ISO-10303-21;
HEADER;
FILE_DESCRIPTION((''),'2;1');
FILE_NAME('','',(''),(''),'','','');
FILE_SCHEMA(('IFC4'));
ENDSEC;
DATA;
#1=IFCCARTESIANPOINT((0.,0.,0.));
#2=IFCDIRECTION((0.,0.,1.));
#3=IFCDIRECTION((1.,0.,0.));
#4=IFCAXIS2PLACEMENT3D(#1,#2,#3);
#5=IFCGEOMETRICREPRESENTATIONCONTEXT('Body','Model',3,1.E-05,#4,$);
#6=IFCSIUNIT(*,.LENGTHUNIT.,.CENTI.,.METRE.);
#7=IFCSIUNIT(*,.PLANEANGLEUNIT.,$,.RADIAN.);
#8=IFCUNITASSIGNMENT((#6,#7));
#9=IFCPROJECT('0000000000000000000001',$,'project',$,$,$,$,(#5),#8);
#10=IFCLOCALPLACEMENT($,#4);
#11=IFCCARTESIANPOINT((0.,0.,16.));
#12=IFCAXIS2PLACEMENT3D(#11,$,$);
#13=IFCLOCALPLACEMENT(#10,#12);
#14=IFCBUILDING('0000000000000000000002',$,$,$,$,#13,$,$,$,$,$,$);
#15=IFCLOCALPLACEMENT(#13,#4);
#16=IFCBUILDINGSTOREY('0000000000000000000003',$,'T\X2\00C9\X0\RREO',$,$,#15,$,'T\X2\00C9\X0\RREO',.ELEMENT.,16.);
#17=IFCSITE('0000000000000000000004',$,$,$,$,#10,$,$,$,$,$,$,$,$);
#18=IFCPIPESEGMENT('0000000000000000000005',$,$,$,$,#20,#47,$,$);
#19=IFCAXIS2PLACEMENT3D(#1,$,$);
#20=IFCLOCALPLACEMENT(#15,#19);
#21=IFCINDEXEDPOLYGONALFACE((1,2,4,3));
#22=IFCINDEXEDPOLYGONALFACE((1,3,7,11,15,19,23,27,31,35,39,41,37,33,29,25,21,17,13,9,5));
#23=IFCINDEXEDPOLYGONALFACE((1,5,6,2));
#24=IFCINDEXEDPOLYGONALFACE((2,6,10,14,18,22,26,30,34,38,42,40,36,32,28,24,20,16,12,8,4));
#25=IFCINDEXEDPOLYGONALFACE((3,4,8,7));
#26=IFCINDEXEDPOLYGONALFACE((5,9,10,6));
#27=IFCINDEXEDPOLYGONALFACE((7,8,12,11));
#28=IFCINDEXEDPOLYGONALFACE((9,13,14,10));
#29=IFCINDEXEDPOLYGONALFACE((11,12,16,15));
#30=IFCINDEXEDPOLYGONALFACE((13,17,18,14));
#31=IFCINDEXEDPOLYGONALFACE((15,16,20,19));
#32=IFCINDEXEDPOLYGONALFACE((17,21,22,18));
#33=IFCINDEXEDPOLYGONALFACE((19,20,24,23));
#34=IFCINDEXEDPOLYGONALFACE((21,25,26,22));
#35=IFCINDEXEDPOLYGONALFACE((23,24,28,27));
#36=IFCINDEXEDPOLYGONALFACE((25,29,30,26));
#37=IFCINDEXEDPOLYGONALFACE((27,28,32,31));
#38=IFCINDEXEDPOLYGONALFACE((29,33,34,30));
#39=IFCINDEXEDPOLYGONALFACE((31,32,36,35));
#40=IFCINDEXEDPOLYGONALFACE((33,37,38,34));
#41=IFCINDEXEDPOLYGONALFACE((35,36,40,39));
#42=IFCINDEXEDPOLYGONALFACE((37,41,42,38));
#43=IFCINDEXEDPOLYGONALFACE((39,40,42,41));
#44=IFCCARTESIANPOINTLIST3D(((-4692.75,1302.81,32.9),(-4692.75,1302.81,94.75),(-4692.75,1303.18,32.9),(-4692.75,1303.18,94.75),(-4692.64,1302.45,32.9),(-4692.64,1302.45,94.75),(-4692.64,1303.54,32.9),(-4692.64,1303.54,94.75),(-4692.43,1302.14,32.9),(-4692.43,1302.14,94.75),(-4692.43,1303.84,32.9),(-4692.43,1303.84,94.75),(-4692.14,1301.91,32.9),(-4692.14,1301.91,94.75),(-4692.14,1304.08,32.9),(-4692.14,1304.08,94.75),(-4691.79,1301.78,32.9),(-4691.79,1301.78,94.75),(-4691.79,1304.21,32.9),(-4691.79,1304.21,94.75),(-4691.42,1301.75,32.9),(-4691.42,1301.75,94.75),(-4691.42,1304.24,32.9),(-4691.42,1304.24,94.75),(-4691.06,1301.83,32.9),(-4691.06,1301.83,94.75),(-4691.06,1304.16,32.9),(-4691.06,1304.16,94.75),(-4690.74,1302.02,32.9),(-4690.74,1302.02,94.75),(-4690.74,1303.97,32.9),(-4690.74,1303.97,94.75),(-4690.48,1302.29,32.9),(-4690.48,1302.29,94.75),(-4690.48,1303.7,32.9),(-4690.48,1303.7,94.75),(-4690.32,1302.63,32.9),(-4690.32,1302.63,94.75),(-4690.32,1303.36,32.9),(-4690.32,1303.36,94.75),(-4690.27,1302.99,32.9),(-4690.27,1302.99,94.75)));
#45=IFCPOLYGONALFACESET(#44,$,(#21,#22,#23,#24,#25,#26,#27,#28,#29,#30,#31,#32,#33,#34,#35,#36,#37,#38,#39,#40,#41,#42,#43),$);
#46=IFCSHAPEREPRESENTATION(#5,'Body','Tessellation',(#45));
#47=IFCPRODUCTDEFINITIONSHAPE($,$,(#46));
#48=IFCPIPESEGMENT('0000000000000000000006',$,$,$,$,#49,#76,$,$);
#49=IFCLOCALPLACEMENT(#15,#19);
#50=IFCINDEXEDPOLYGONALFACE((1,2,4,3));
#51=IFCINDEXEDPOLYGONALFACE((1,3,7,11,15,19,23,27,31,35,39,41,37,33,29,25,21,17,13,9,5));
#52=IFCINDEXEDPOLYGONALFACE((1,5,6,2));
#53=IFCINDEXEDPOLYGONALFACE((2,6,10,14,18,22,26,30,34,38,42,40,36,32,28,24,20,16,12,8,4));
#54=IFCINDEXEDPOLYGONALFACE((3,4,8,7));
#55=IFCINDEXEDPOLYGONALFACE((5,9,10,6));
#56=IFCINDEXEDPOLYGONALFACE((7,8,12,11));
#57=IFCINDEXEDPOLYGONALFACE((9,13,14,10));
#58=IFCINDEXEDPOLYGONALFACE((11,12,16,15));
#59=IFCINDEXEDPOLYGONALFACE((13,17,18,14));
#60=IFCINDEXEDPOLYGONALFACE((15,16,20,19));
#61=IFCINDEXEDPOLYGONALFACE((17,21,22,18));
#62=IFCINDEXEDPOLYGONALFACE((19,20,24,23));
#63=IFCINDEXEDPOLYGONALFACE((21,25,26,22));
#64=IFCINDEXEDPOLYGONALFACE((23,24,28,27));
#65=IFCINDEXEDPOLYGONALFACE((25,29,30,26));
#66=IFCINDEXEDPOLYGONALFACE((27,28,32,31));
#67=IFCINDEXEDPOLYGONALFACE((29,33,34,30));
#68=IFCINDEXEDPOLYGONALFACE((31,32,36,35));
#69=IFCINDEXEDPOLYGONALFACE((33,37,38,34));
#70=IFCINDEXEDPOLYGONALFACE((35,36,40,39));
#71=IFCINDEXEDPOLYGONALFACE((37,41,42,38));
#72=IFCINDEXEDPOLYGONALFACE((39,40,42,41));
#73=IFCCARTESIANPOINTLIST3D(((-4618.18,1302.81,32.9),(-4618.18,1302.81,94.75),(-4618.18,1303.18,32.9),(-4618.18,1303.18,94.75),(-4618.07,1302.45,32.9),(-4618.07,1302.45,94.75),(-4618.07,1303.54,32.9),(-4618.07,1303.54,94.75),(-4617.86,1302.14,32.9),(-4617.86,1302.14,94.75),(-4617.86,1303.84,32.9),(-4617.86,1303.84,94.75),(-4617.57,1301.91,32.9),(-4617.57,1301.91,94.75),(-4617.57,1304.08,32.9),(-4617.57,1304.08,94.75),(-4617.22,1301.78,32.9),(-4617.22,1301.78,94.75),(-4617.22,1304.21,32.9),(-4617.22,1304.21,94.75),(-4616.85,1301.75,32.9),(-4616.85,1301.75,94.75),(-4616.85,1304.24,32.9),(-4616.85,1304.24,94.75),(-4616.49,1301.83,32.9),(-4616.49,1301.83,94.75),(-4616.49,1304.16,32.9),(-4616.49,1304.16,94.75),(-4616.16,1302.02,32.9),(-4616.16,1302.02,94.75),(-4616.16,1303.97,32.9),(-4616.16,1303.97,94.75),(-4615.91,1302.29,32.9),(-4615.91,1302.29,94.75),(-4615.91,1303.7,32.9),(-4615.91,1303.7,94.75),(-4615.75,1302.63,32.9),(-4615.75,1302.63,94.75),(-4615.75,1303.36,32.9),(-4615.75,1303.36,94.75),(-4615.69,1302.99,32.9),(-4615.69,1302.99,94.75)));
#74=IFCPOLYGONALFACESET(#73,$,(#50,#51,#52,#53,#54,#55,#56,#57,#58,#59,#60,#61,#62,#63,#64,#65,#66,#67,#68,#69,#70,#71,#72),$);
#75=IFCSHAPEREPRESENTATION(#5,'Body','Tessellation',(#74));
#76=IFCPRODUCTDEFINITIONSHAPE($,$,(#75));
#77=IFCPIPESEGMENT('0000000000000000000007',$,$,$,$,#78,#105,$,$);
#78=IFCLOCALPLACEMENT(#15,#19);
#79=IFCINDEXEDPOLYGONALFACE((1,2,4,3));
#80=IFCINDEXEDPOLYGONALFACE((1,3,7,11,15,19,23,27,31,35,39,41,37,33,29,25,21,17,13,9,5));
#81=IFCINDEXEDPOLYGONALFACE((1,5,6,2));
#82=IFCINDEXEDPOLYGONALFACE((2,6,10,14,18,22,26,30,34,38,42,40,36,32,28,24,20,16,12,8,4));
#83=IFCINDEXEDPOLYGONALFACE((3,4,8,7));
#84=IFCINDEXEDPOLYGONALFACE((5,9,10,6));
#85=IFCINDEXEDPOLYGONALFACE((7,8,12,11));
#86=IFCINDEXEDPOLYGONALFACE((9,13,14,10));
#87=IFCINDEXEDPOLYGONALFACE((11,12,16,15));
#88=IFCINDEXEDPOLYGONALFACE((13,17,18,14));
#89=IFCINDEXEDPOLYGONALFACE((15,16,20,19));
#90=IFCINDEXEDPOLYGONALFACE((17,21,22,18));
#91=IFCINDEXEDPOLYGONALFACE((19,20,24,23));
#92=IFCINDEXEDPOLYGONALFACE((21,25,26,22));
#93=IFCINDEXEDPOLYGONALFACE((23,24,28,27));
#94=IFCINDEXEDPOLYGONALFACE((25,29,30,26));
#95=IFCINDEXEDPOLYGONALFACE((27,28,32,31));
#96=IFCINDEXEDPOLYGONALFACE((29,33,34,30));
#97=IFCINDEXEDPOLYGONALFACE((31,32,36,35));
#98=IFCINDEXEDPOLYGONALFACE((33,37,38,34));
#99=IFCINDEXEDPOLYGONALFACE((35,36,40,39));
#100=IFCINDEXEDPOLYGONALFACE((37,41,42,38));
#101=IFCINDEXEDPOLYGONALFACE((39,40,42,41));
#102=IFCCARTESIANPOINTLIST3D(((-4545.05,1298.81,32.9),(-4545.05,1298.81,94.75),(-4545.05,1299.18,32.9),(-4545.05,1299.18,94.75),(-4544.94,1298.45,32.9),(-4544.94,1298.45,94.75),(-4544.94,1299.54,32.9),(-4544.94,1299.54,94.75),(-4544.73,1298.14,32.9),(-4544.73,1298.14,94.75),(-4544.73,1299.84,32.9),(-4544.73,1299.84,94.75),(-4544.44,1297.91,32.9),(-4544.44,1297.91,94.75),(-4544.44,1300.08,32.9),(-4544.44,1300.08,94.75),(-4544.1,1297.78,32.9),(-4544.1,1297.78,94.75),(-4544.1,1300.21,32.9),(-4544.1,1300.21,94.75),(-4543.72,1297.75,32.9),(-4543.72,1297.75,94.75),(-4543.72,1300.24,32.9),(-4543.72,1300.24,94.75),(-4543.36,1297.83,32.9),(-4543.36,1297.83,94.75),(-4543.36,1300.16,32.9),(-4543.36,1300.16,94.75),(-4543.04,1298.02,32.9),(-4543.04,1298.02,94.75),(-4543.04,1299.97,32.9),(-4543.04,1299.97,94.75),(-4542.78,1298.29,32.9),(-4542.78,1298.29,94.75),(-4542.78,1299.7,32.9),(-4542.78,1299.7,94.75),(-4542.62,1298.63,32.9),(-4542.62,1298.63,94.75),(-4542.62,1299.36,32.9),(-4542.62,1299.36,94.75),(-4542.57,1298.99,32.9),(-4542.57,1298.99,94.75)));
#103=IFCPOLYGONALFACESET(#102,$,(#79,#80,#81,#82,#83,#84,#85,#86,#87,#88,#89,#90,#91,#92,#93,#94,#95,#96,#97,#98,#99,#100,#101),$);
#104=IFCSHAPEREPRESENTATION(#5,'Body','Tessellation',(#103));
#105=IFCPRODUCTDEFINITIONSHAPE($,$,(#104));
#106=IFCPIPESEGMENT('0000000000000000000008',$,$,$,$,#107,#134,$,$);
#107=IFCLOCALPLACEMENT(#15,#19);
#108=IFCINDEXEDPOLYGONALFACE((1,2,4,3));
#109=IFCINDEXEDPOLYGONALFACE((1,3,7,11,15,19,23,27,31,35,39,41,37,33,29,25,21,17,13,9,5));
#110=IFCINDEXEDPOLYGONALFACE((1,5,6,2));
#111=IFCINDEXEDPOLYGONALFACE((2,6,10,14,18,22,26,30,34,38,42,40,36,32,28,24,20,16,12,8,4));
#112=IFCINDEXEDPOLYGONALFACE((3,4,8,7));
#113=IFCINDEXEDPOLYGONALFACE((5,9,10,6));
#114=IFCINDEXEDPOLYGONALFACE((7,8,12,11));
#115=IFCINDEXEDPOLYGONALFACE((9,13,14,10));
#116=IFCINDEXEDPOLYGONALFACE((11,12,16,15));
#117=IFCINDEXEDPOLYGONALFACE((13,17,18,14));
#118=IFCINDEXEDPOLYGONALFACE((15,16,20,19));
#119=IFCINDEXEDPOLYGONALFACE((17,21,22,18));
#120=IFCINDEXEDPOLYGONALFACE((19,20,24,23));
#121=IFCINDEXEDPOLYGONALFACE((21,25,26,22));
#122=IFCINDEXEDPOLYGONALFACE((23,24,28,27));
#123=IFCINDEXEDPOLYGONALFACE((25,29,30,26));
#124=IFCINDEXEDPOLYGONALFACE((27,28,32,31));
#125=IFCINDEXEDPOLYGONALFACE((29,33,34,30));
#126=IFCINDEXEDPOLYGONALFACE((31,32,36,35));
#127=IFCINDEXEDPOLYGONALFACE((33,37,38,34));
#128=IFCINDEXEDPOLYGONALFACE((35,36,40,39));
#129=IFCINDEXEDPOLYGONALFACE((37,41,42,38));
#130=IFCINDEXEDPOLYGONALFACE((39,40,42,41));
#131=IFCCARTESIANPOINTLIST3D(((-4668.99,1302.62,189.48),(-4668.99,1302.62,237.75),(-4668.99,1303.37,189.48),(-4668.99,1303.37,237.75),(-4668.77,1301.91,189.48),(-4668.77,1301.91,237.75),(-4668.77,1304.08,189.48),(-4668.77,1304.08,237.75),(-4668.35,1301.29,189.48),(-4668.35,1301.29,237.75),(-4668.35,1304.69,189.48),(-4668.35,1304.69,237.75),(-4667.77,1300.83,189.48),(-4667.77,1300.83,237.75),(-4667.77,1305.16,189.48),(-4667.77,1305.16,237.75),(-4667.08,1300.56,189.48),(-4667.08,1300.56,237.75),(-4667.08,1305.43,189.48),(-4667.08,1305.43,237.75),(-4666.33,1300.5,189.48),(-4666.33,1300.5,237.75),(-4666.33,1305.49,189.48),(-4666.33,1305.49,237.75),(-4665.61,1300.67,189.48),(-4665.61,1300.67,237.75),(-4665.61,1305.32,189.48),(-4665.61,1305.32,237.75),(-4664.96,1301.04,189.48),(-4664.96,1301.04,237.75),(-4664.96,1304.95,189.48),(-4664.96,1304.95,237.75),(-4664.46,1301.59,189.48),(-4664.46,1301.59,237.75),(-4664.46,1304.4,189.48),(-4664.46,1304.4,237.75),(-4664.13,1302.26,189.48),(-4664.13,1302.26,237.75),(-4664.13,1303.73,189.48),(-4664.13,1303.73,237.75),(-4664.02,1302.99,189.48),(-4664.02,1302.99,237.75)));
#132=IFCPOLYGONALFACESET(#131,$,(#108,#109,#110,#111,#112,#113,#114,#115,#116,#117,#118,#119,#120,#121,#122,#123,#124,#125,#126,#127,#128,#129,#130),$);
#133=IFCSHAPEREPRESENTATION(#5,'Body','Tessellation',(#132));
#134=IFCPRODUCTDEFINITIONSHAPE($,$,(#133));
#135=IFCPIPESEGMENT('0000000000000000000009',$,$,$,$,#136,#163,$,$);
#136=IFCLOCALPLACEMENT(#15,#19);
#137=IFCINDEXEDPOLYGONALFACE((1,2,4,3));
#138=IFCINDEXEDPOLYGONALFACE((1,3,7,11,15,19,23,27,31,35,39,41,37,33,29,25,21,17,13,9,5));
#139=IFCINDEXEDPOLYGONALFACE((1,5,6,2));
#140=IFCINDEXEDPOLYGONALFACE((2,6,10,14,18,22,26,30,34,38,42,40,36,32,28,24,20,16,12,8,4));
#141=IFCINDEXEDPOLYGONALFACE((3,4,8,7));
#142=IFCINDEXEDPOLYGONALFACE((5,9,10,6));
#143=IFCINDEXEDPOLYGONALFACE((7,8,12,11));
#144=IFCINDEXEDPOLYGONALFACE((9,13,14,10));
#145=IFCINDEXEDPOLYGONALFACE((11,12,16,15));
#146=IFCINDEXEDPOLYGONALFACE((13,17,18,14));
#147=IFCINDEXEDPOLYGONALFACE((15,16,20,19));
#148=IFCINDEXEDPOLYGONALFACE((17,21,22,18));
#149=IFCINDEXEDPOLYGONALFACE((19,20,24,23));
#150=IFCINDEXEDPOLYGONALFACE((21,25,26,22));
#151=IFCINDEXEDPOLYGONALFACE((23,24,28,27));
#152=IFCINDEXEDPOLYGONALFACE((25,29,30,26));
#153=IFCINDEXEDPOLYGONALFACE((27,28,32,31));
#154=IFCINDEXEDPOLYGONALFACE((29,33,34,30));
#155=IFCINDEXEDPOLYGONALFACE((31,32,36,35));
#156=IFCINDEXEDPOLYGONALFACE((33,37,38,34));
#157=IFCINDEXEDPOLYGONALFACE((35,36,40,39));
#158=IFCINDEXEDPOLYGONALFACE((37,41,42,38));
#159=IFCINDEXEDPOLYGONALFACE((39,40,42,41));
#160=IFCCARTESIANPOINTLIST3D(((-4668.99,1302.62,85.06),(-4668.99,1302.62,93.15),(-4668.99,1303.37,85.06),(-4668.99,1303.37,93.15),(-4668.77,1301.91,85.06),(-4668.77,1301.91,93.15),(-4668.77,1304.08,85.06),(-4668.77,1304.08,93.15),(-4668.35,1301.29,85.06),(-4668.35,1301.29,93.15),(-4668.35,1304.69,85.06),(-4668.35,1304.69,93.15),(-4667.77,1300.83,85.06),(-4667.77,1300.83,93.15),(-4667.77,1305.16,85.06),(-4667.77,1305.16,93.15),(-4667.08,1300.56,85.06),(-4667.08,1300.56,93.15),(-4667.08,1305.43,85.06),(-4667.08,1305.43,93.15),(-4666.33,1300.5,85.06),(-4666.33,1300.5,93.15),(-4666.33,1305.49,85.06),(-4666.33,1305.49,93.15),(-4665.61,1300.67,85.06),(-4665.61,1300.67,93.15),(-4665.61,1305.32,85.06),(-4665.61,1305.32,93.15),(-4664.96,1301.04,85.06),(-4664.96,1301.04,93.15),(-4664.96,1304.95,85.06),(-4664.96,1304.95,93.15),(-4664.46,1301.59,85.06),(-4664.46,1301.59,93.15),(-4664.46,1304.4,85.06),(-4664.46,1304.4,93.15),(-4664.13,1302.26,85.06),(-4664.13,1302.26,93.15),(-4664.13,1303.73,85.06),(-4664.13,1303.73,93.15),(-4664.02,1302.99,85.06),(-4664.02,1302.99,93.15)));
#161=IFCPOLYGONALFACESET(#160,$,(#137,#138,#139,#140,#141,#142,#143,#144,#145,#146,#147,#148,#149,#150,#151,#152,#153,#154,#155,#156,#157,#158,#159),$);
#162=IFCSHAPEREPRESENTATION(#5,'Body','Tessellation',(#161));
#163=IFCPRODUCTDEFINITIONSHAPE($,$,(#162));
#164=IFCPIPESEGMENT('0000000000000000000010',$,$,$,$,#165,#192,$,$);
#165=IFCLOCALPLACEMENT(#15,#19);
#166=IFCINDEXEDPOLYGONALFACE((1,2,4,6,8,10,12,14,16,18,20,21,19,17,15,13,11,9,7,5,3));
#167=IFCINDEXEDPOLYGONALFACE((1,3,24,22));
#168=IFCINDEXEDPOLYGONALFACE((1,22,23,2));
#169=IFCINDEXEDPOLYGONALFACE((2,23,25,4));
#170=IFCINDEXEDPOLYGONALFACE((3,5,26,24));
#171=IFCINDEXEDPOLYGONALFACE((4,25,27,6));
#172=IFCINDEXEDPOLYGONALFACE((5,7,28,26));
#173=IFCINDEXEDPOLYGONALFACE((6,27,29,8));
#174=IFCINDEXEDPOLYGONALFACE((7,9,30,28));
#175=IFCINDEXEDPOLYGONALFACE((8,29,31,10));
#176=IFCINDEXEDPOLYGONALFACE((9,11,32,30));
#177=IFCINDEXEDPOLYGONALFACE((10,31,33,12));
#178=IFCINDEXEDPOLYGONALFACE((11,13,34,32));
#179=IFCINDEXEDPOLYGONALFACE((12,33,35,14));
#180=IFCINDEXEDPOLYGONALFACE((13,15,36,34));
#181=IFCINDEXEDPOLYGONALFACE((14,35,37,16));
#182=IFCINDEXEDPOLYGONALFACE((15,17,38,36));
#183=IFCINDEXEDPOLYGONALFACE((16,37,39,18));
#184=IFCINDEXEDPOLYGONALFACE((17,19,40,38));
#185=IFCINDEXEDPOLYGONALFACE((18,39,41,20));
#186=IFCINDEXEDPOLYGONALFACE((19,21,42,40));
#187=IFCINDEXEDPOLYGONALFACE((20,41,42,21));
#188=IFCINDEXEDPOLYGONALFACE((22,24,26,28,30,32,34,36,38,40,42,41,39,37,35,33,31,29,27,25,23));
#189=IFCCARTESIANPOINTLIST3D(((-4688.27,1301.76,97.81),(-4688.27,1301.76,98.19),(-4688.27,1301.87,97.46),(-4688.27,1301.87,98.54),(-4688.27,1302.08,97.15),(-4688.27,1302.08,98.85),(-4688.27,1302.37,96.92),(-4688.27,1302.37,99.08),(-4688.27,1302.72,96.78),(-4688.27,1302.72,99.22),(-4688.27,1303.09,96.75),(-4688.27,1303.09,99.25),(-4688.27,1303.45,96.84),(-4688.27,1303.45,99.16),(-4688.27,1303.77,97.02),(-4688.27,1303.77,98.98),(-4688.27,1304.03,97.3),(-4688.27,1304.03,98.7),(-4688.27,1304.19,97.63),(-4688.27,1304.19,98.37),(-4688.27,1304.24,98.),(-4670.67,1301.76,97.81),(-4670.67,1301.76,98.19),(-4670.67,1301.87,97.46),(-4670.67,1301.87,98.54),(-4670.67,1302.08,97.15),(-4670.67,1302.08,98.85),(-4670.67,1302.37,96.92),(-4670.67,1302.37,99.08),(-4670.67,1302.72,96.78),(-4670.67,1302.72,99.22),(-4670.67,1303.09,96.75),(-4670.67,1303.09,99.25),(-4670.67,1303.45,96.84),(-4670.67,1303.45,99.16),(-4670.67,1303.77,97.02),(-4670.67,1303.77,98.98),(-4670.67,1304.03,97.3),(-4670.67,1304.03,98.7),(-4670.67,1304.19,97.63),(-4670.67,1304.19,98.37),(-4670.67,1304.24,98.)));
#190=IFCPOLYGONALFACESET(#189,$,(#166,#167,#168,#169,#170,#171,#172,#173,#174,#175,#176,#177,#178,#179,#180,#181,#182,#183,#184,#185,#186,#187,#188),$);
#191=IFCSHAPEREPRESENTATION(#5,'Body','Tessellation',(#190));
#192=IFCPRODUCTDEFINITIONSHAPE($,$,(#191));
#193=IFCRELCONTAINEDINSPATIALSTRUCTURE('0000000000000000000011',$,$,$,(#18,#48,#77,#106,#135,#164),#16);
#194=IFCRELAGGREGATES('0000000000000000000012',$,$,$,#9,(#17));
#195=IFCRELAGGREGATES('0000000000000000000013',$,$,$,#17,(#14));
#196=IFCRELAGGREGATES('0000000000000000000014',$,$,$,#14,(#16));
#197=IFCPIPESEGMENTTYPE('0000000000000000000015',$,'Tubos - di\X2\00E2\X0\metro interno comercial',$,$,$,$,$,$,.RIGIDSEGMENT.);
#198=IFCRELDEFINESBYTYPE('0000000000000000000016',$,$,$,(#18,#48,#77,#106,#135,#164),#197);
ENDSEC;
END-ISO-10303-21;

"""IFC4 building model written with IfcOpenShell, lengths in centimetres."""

from ifc_helpers import new_model, si_unit, frame, origin_with_axes, origin_2d_with_axis, place, context, project, spatial, circle, extrude, type_object, element, save


model = new_model("IFC4")

# Units and contexts
model_context = context("Model", 3, precision=1e-05, world=origin_with_axes(), identifier="Body")
ifc_project = project(units=[si_unit("LENGTHUNIT", "METRE", prefix="CENTI"), si_unit("PLANEANGLEUNIT", "RADIAN")], contexts=[model_context])

# Site, building, storey
site_placement = place(None, origin_with_axes())
site = spatial("IfcSite", under=ifc_project, at=site_placement)
building_placement = place(site_placement, frame((0.0, 0.0, 16.0)))
building = spatial("IfcBuilding", under=site, at=building_placement)
storey_placement = place(building_placement, origin_with_axes())
storey = spatial("IfcBuildingStorey", under=building, at=storey_placement, Name="TÉRREO", LongName="TÉRREO", CompositionType="ELEMENT", Elevation=16.0)

# Pipe segments
pipe_segment_type = type_object("IfcPipeSegmentType", Name="Tubos - diâmetro interno comercial", PredefinedType="RIGIDSEGMENT")
for number, where, z_axis, x_axis in (
    (1, (-4691.52, 1302.99, 94.75), (0.0, 0.0, 1.0), (1.0, 0.0, 0.0)),
    (2, (-4616.94, 1302.99, 94.75), (0.0, 0.0, 1.0), (1.0, 0.0, 0.0)),
    (3, (-4543.82, 1298.99, 94.75), (0.0, 0.0, 1.0), (1.0, 0.0, 0.0)),
):
    element("IfcPipeSegment", number, at=place(storey_placement, frame(where, z_axis=z_axis, x_axis=x_axis)), inside=storey, type_object=pipe_segment_type, context=model_context, shape_type="SolidModel", body=[
        extrude(circle(Radius=1.25, at=origin_2d_with_axis()), frame((0.0, 0.0, 0.0), z_axis=(0.0, 0.0, -1.0), x_axis=(1.0, 0.0, 0.0)), (0.0, 0.0, 1.0), 61.85),
    ])
pipe_segment_1_placement = place(storey_placement, frame((-4666.52, 1302.99, 237.75), z_axis=(0.0, 0.0, 1.0), x_axis=(1.0, 0.0, 0.0)))
element("IfcPipeSegment", 4, at=pipe_segment_1_placement, inside=storey, type_object=pipe_segment_type, context=model_context, shape_type="SolidModel", body=[
    extrude(circle(Radius=2.5, at=origin_2d_with_axis()), frame((0.0, 0.0, 0.0), z_axis=(0.0, 0.0, -1.0), x_axis=(1.0, 0.0, 0.0)), (0.0, 0.0, 1.0), 48.27),
])
pipe_segment_2_placement = place(storey_placement, frame((-4666.52, 1302.99, 93.15), z_axis=(0.0, 0.0, 1.0), x_axis=(1.0, 0.0, 0.0)))
element("IfcPipeSegment", 5, at=pipe_segment_2_placement, inside=storey, type_object=pipe_segment_type, context=model_context, shape_type="SolidModel", body=[
    extrude(circle(Radius=2.5, at=origin_2d_with_axis()), frame((0.0, 0.0, 0.0), z_axis=(0.0, 0.0, -1.0), x_axis=(1.0, 0.0, 0.0)), (0.0, 0.0, 1.0), 8.09),
])
pipe_segment_3_placement = place(storey_placement, frame((-4679.47, 1302.99, 99.25), z_axis=(0.0, 0.0, 1.0), x_axis=(1.0, 0.0, 0.0)))
element("IfcPipeSegment", 6, at=pipe_segment_3_placement, inside=storey, type_object=pipe_segment_type, context=model_context, shape_type="SolidModel", body=[
    extrude(circle(Radius=1.25, at=origin_2d_with_axis()), frame((8.8, 0.0, -1.25), z_axis=(-1.0, 0.0, 0.0), x_axis=(0.0, 1.0, 0.0)), (0.0, 0.0, 1.0), 17.6),
])

save(model, "model.ifc")
